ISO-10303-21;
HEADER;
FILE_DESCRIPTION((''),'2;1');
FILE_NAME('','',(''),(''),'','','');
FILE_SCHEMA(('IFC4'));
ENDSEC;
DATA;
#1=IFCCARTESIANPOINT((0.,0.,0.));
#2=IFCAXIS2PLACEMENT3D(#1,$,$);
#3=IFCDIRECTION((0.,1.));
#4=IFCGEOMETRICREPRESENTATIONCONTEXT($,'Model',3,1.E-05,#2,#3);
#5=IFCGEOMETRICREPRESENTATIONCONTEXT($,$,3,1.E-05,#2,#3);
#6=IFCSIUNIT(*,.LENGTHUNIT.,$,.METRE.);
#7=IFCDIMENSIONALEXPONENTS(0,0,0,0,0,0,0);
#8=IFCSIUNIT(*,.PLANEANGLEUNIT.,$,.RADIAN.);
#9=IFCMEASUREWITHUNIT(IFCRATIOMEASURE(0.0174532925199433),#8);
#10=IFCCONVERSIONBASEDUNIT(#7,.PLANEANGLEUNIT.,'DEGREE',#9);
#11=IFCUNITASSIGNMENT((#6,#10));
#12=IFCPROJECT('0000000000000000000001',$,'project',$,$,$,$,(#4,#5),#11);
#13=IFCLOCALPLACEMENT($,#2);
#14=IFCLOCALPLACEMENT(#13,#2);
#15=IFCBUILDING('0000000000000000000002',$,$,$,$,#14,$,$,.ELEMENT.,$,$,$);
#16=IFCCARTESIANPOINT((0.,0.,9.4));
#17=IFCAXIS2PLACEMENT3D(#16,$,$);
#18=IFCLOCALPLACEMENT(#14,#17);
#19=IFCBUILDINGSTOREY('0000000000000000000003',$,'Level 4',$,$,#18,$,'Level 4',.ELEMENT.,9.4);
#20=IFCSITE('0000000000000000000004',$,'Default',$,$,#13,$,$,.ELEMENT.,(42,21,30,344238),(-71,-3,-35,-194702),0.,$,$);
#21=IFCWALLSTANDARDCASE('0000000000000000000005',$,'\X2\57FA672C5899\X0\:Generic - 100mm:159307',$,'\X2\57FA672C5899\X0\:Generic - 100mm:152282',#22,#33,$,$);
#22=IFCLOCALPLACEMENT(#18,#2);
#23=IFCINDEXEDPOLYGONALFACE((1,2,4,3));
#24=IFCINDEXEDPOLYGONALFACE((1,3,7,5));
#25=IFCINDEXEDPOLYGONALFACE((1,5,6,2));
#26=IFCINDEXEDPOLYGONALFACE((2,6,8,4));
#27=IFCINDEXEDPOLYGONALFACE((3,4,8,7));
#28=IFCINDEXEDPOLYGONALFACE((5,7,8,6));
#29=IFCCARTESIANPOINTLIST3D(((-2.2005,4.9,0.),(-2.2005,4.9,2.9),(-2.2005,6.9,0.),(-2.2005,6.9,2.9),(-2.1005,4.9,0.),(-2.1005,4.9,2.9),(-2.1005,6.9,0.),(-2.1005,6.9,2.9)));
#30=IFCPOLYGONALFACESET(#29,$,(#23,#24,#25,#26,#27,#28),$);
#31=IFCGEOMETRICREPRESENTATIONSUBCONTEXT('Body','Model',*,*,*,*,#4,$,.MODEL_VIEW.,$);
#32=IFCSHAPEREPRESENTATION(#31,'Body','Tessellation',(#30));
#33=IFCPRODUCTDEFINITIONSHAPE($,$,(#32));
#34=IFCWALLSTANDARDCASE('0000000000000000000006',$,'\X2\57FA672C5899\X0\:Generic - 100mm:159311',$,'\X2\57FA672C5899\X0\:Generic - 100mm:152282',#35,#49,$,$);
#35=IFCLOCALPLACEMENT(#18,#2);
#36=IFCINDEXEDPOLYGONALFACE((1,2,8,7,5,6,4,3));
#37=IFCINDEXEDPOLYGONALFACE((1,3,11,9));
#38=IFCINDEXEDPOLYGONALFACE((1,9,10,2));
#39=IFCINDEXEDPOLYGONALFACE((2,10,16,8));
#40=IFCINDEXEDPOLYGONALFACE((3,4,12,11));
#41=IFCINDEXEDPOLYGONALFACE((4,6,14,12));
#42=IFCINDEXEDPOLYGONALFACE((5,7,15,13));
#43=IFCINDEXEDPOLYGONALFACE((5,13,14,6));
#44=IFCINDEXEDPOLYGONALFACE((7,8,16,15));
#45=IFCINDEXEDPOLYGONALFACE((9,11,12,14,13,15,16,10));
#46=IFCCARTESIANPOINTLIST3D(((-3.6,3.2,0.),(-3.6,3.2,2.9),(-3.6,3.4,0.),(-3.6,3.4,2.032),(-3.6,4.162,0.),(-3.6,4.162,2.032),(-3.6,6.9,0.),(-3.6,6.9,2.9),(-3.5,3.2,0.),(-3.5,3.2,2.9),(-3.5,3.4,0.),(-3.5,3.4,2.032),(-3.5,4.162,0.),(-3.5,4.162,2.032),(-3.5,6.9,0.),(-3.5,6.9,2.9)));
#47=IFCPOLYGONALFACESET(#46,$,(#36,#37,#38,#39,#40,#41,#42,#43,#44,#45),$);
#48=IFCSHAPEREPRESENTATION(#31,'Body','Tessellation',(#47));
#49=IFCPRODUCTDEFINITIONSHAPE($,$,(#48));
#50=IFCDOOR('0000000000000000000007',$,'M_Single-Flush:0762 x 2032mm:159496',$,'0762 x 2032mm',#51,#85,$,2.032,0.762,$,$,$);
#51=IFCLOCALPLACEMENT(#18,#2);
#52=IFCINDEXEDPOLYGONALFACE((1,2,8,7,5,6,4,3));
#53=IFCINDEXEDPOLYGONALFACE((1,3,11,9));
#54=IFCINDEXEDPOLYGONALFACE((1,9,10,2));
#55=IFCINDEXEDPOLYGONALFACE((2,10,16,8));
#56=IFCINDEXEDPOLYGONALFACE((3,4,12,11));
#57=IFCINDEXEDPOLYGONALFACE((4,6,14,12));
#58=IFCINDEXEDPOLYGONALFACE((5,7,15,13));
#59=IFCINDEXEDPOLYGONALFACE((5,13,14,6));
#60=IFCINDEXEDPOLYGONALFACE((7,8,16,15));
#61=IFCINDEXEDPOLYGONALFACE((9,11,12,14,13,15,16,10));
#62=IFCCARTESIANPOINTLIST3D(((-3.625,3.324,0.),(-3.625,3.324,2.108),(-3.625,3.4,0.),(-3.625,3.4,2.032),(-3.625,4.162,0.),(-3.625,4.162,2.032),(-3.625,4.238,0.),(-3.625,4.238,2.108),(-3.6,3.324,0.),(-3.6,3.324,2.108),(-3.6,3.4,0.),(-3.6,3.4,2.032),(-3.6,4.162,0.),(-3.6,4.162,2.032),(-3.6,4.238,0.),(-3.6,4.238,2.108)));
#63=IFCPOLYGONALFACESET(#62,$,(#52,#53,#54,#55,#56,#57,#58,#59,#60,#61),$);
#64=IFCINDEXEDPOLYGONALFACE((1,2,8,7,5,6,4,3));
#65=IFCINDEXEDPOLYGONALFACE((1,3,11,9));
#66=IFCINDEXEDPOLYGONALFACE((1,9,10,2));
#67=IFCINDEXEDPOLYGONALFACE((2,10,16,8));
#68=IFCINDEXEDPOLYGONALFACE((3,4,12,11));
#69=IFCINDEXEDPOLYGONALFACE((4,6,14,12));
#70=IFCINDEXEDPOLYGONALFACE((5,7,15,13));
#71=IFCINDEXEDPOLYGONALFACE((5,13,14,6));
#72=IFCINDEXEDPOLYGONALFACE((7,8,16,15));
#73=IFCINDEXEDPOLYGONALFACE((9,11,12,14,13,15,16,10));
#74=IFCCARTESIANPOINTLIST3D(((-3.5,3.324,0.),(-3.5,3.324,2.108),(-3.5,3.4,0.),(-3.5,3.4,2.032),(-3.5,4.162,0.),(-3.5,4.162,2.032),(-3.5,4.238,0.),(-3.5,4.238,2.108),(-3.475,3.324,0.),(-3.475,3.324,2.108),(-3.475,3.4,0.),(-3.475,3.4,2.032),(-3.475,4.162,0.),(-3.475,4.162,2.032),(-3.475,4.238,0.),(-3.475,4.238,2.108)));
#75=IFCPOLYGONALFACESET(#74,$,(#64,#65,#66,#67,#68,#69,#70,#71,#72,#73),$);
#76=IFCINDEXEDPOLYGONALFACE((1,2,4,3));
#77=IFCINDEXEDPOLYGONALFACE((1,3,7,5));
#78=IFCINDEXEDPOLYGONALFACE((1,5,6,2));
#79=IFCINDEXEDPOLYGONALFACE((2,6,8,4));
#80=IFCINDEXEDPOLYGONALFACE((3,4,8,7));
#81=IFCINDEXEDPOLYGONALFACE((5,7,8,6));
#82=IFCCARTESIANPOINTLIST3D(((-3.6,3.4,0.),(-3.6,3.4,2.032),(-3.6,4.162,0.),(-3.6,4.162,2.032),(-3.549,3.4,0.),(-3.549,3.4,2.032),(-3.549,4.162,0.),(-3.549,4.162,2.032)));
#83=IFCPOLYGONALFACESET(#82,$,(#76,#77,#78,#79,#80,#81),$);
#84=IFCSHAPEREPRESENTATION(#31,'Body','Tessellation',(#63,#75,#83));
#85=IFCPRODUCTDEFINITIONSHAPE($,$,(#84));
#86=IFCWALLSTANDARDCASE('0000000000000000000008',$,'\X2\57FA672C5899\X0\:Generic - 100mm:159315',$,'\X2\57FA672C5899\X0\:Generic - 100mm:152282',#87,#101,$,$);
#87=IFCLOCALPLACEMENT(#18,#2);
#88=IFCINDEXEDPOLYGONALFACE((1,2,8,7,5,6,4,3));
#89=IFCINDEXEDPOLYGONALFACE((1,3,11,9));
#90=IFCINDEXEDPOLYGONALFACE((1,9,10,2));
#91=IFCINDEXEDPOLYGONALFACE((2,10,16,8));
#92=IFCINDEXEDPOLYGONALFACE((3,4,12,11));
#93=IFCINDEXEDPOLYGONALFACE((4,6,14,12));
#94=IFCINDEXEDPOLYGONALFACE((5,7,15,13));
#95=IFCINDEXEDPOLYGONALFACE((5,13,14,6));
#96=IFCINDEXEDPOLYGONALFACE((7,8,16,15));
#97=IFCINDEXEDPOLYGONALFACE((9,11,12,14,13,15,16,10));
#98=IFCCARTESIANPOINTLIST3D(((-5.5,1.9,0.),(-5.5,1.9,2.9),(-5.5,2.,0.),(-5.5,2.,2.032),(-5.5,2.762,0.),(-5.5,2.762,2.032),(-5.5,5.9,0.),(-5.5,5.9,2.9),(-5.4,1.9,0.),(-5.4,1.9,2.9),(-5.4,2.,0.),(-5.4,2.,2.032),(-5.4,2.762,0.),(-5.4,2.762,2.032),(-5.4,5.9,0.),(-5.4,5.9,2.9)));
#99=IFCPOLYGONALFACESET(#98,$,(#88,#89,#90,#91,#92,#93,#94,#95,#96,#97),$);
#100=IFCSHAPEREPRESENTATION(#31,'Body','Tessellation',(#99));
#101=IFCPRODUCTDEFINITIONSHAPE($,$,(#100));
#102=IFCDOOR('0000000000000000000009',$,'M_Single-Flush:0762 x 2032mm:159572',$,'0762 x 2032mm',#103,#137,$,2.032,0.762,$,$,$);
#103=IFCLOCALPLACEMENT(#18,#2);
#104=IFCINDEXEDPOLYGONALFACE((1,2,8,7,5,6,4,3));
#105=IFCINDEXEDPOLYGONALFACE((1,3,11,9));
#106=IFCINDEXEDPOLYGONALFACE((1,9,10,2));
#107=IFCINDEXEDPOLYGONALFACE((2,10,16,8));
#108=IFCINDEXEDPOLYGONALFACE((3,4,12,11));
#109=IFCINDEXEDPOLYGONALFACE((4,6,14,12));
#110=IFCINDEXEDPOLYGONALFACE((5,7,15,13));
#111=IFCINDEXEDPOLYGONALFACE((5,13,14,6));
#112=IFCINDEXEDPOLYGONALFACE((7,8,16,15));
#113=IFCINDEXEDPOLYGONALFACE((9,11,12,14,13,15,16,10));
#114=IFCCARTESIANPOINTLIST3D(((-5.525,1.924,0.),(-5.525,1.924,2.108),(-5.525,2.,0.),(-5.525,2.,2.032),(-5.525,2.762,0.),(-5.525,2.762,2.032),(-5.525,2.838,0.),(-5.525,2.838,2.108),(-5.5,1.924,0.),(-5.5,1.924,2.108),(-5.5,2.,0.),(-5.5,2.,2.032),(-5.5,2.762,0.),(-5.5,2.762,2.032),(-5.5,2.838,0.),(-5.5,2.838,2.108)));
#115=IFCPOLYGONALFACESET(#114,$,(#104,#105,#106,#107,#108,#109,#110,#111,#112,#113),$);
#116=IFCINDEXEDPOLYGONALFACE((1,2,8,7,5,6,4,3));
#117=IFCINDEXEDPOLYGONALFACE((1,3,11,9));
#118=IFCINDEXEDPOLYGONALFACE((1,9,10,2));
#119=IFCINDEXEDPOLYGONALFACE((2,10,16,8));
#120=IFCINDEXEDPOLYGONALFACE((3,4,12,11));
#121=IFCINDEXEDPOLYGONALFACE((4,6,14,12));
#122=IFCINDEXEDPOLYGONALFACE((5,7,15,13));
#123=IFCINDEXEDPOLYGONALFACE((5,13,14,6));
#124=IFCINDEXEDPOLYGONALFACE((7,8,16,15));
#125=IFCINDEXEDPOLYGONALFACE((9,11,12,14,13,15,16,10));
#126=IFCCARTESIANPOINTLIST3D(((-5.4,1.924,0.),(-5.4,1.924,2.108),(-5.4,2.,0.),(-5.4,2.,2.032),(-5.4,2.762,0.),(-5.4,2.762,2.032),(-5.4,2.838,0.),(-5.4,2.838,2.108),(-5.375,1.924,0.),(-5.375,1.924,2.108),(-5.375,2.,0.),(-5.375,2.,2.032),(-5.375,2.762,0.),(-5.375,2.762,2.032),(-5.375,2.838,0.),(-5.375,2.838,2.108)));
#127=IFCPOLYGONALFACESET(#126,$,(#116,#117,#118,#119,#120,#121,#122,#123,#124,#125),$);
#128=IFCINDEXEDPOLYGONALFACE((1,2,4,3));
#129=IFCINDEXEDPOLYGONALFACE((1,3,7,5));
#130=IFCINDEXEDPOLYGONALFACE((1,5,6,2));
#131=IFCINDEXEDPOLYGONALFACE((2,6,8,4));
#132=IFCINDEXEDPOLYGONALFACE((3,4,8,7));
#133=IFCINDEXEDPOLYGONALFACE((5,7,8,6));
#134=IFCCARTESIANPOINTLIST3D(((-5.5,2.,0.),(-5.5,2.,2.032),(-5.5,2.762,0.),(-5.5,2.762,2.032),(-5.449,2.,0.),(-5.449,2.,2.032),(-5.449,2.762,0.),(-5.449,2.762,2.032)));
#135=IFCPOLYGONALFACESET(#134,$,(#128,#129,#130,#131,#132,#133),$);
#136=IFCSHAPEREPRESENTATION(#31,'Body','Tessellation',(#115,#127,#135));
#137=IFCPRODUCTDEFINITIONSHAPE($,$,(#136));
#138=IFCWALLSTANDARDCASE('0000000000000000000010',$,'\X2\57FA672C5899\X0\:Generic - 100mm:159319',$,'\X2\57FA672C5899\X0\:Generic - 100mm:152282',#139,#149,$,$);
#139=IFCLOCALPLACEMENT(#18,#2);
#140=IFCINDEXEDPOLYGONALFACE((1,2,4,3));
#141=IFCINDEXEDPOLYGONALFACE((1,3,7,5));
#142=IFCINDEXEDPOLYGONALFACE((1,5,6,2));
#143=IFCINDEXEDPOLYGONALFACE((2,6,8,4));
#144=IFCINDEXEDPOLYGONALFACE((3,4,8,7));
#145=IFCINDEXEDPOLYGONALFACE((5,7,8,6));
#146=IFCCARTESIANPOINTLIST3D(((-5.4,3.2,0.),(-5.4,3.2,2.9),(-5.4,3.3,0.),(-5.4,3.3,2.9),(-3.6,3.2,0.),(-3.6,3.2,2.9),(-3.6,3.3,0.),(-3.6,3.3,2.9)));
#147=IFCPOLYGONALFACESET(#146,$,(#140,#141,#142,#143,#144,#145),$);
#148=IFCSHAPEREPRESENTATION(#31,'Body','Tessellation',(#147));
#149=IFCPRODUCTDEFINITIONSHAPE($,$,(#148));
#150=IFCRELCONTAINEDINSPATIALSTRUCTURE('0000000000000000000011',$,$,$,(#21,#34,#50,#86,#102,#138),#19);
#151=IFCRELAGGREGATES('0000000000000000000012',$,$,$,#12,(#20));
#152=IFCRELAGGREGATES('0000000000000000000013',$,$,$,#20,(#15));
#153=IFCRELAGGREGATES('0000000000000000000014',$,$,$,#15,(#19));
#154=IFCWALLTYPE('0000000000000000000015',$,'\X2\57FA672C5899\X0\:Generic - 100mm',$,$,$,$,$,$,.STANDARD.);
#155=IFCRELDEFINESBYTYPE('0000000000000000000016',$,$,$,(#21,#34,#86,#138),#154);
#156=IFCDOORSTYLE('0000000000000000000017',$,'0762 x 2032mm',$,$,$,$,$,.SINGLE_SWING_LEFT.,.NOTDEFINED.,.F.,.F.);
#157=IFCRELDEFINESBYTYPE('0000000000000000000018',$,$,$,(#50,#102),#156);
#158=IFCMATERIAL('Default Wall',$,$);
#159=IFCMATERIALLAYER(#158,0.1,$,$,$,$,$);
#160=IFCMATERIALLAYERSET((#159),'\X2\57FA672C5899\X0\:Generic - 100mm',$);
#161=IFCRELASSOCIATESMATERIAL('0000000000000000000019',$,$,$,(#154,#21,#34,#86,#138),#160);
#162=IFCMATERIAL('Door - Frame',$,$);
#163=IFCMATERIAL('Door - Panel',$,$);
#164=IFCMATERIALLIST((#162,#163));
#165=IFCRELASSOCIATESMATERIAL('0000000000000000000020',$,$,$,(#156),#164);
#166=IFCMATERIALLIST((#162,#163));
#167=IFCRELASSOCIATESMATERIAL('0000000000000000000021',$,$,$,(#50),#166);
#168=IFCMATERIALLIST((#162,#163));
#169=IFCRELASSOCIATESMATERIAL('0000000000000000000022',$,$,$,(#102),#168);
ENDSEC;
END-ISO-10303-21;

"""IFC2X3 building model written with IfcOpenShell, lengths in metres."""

from ifc_helpers import new_model, entity, si_unit, converted_unit, direction, frame, frame_2d, origin, origin_2d_with_axis, place, context, subcontext, project, spatial, polyline, rectangle, outline, extrude, clip, bounded_halfspace, source, transform, mapped, material, material_list, layer, layer_set, layer_usage, type_object, type_shapes, element, fill, save


model = new_model("IFC2X3")

# Units and contexts
model_context = context("Model", 3, precision=1e-05, world=origin(), true_north=direction((0.0, 1.0)))
context_of_model = context(None, 3, precision=1e-05, world=origin(), true_north=direction((0.0, 1.0)))
body_context = subcontext(model_context, "Body", "Model", "MODEL_VIEW")
ifc_project = project(units=[si_unit("LENGTHUNIT", "METRE"), converted_unit("PLANEANGLEUNIT", "DEGREE", entity("IfcRatioMeasure", 0.0174532925199433), si_unit("PLANEANGLEUNIT", "RADIAN"), dimensions=[0, 0, 0, 0, 0, 0, 0])], contexts=[model_context, context_of_model])

# Site, building, storey
site_placement = place(None, origin())
site = spatial("IfcSite", under=ifc_project, at=site_placement, Name="Default", CompositionType="ELEMENT", RefLatitude=(42, 21, 30, 344238), RefLongitude=(-71, -3, -35, -194702), RefElevation=0.0)
building_placement = place(site_placement, origin())
building = spatial("IfcBuilding", under=site, at=building_placement, CompositionType="ELEMENT")
storey_placement = place(building_placement, frame((0.0, 0.0, 9.4)))
storey = spatial("IfcBuildingStorey", under=building, at=storey_placement, Name="Level 4", LongName="Level 4", CompositionType="ELEMENT", Elevation=9.4)

# Shared definitions
ifc_material_1 = material(Name="Default Wall")

# Shared definitions
ifc_layer_1 = layer(ifc_material_1, 0.1)
ifc_layer_set_1 = layer_set([ifc_layer_1], Name="基本墙:Generic - 100mm")
wall_type_1 = type_object("IfcWallType", Name="基本墙:Generic - 100mm", PredefinedType="STANDARD", material=ifc_layer_set_1)
ifc_material_2 = material(Name="Door - Panel")
ifc_material_3 = material(Name="Door - Frame")

# Wall
ifc_layer_usage_1 = layer_usage(ifc_layer_set_1, "AXIS2", "NEGATIVE", 0.05)
wall_1_placement = place(storey_placement, frame((-2.1505, 4.9, 0.0), z_axis=(0.0, 0.0, 1.0), x_axis=(0.0, 1.0, 0.0)))
element("IfcWallStandardCase", 1, at=wall_1_placement, inside=storey, type_object=wall_type_1, material=ifc_layer_usage_1, Name="基本墙:Generic - 100mm:159307", ObjectType="基本墙:Generic - 100mm:152282", context=body_context, shape_type="Clipping", body=[
    clip(extrude(rectangle(XDim=2.0, YDim=0.1, at=frame_2d((1.0, 0.0), x_axis=(-1.0, 0.0))), origin(), (0.0, 0.0, 1.0), 3.2), bounded_halfspace(frame((0.0, -0.05, 2.9), z_axis=(0.0, 0.0, -1.0), x_axis=(-1.0, 0.0, 0.0)), True, frame((0.0, -0.05, 2.9), z_axis=(0.0, 0.0, -1.0), x_axis=(-1.0, 0.0, 0.0)), polyline([(0.0, 0.0), (0.0, 0.1), (-2.0, 0.1), (-2.0, 0.0), (0.0, 0.0)]))),
])

# Walls, openings, doors
ifc_layer_usage_2 = layer_usage(ifc_layer_set_1, "AXIS2", "NEGATIVE", 0.05)
wall_2_placement = place(storey_placement, frame((-3.55, 6.9, 0.0), z_axis=(0.0, 0.0, 1.0), x_axis=(0.0, -1.0, 0.0)))
wall_2 = element("IfcWallStandardCase", 2, at=wall_2_placement, inside=storey, type_object=wall_type_1, material=ifc_layer_usage_2, Name="基本墙:Generic - 100mm:159311", ObjectType="基本墙:Generic - 100mm:152282", context=body_context, shape_type="Clipping", body=[
    clip(extrude(rectangle(XDim=3.7, YDim=0.1, at=frame_2d((1.85, 0.0), x_axis=(-1.0, 0.0))), origin(), (0.0, 0.0, 1.0), 3.2), bounded_halfspace(frame((0.0, -0.05, 2.9), z_axis=(0.0, 0.0, -1.0), x_axis=(1.0, 0.0, 0.0)), True, frame((0.0, -0.05, 2.9), z_axis=(0.0, 0.0, -1.0), x_axis=(1.0, 0.0, 0.0)), polyline([(0.0, 0.0), (0.0, -0.1), (2.0, -0.1), (2.1, -0.1), (3.7, -0.1), (3.7, 0.0), (3.6, 0.0), (2.1, 0.0), (2.0, 0.0), (0.0, 0.0)]))),
])
opening_1_placement = place(wall_2_placement, frame((3.5, 0.05, 0.0)))
opening_1 = element("IfcOpeningElement", 3, at=opening_1_placement, cuts=wall_2, ObjectType="Opening", context=body_context, shape_type="SweptSolid", body=[
    extrude(rectangle(XDim=0.762, YDim=2.032, at=frame_2d((1.016, 0.381), x_axis=(0.0, -1.0))), frame((0.0, 0.0, 0.0), z_axis=(0.0, -1.0, 0.0), x_axis=(0.0, 0.0, 1.0)), (0.0, 0.0, 1.0), 0.1),
])
ifc_material_list_1 = material_list([ifc_material_3, ifc_material_2])
ifc_material_list_2 = material_list([ifc_material_3, ifc_material_2])
door_style_1 = type_object("IfcDoorStyle", Name="0762 x 2032mm", ConstructionType="NOTDEFINED", OperationType="SINGLE_SWING_LEFT", ParameterTakesPrecedence=False, Sizeable=False, material=ifc_material_list_2)
shared_shape_1 = source(origin(), body_context, "Body", "SweptSolid", [
    extrude(outline(polyline([(-0.457, -1.073), (0.457, -1.073), (0.457, 1.035), (0.381, 1.035), (0.381, -0.997), (-0.381, -0.997), (-0.381, 1.035), (-0.457, 1.035), (-0.457, -1.073)])), frame((0.381, 0.125, 1.035), z_axis=(0.0, -1.0, 0.0), x_axis=(-1.0, 0.0, 0.0)), (0.0, 0.0, 1.0), 0.025),
    extrude(outline(polyline([(-1.073, -0.457), (1.035, -0.457), (1.035, -0.381), (-0.997, -0.381), (-0.997, 0.381), (1.035, 0.381), (1.035, 0.457), (-1.073, 0.457), (-1.073, -0.457)])), frame((0.381, 0.0, 1.035), z_axis=(0.0, -1.0, 0.0), x_axis=(0.0, 0.0, -1.0)), (0.0, 0.0, 1.0), 0.025),
    extrude(rectangle(XDim=0.762, YDim=0.051, at=origin_2d_with_axis()), frame((0.381, 0.0745, 0.0)), (0.0, 0.0, 1.0), 2.032),
])
type_shapes(door_style_1, [shared_shape_1])
door_1_placement = place(opening_1_placement, frame((0.0, 0.0, 0.0), z_axis=(0.0, 0.0, 1.0), x_axis=(-1.0, 0.0, 0.0)))
door_1 = element("IfcDoor", 4, at=door_1_placement, inside=storey, type_object=door_style_1, material=ifc_material_list_1, Name="M_Single-Flush:0762 x 2032mm:159496", ObjectType="0762 x 2032mm", OverallHeight=2.032, OverallWidth=0.762, context=body_context, shape_type="MappedRepresentation", body=[
    mapped(shared_shape_1, transform((0.0, 0.0, 0.0), scale=1.0)),
])
fill(opening_1, door_1)
ifc_layer_usage_3 = layer_usage(ifc_layer_set_1, "AXIS2", "NEGATIVE", 0.05)
wall_3_placement = place(storey_placement, frame((-5.45, 5.9, 0.0), z_axis=(0.0, 0.0, 1.0), x_axis=(0.0, -1.0, 0.0)))
wall_3 = element("IfcWallStandardCase", 5, at=wall_3_placement, inside=storey, type_object=wall_type_1, material=ifc_layer_usage_3, Name="基本墙:Generic - 100mm:159315", ObjectType="基本墙:Generic - 100mm:152282", context=body_context, shape_type="Clipping", body=[
    clip(extrude(rectangle(XDim=4.0, YDim=0.1, at=frame_2d((2.0, 0.0), x_axis=(-1.0, 0.0))), origin(), (0.0, 0.0, 1.0), 3.2), bounded_halfspace(frame((0.0, -0.05, 2.9), z_axis=(0.0, 0.0, -1.0), x_axis=(1.0, 0.0, 0.0)), True, frame((0.0, -0.05, 2.9), z_axis=(0.0, 0.0, -1.0), x_axis=(1.0, 0.0, 0.0)), polyline([(0.0, 0.0), (0.0, -0.1), (4.0, -0.1), (4.0, 0.0), (0.0, 0.0)]))),
])
opening_2_placement = place(wall_3_placement, frame((3.9, 0.05, 0.0)))
opening_2 = element("IfcOpeningElement", 6, at=opening_2_placement, cuts=wall_3, ObjectType="Opening", context=body_context, shape_type="SweptSolid", body=[
    extrude(rectangle(XDim=0.762, YDim=2.032, at=frame_2d((1.016, 0.381), x_axis=(0.0, -1.0))), frame((0.0, 0.0, 0.0), z_axis=(0.0, -1.0, 0.0), x_axis=(0.0, 0.0, 1.0)), (0.0, 0.0, 1.0), 0.1),
])
ifc_material_list_3 = material_list([ifc_material_3, ifc_material_2])
door_2_placement = place(opening_2_placement, frame((0.0, 0.0, 0.0), z_axis=(0.0, 0.0, 1.0), x_axis=(-1.0, 0.0, 0.0)))
door_2 = element("IfcDoor", 7, at=door_2_placement, inside=storey, type_object=door_style_1, material=ifc_material_list_3, Name="M_Single-Flush:0762 x 2032mm:159572", ObjectType="0762 x 2032mm", OverallHeight=2.032, OverallWidth=0.762, context=body_context, shape_type="MappedRepresentation", body=[
    mapped(shared_shape_1, transform((0.0, 0.0, 0.0), scale=1.0)),
])
fill(opening_2, door_2)

# Wall
ifc_layer_usage_4 = layer_usage(ifc_layer_set_1, "AXIS2", "NEGATIVE", 0.05)
wall_4_placement = place(storey_placement, frame((-3.6, 3.25, 0.0), z_axis=(0.0, 0.0, 1.0), x_axis=(-1.0, 0.0, 0.0)))
element("IfcWallStandardCase", 8, at=wall_4_placement, inside=storey, type_object=wall_type_1, material=ifc_layer_usage_4, Name="基本墙:Generic - 100mm:159319", ObjectType="基本墙:Generic - 100mm:152282", context=body_context, shape_type="Clipping", body=[
    clip(extrude(rectangle(XDim=1.8, YDim=0.1, at=frame_2d((0.9, 0.0), x_axis=(-1.0, 0.0))), origin(), (0.0, 0.0, 1.0), 3.2), bounded_halfspace(frame((0.0, -0.05, 2.9), z_axis=(0.0, 0.0, -1.0), x_axis=(0.0, 1.0, 0.0)), True, frame((0.0, -0.05, 2.9), z_axis=(0.0, 0.0, -1.0), x_axis=(0.0, 1.0, 0.0)), polyline([(0.0, 0.0), (0.1, 0.0), (0.1, 1.8), (0.0, 1.8), (0.0, 0.0)]))),
])

save(model, "model.ifc")
